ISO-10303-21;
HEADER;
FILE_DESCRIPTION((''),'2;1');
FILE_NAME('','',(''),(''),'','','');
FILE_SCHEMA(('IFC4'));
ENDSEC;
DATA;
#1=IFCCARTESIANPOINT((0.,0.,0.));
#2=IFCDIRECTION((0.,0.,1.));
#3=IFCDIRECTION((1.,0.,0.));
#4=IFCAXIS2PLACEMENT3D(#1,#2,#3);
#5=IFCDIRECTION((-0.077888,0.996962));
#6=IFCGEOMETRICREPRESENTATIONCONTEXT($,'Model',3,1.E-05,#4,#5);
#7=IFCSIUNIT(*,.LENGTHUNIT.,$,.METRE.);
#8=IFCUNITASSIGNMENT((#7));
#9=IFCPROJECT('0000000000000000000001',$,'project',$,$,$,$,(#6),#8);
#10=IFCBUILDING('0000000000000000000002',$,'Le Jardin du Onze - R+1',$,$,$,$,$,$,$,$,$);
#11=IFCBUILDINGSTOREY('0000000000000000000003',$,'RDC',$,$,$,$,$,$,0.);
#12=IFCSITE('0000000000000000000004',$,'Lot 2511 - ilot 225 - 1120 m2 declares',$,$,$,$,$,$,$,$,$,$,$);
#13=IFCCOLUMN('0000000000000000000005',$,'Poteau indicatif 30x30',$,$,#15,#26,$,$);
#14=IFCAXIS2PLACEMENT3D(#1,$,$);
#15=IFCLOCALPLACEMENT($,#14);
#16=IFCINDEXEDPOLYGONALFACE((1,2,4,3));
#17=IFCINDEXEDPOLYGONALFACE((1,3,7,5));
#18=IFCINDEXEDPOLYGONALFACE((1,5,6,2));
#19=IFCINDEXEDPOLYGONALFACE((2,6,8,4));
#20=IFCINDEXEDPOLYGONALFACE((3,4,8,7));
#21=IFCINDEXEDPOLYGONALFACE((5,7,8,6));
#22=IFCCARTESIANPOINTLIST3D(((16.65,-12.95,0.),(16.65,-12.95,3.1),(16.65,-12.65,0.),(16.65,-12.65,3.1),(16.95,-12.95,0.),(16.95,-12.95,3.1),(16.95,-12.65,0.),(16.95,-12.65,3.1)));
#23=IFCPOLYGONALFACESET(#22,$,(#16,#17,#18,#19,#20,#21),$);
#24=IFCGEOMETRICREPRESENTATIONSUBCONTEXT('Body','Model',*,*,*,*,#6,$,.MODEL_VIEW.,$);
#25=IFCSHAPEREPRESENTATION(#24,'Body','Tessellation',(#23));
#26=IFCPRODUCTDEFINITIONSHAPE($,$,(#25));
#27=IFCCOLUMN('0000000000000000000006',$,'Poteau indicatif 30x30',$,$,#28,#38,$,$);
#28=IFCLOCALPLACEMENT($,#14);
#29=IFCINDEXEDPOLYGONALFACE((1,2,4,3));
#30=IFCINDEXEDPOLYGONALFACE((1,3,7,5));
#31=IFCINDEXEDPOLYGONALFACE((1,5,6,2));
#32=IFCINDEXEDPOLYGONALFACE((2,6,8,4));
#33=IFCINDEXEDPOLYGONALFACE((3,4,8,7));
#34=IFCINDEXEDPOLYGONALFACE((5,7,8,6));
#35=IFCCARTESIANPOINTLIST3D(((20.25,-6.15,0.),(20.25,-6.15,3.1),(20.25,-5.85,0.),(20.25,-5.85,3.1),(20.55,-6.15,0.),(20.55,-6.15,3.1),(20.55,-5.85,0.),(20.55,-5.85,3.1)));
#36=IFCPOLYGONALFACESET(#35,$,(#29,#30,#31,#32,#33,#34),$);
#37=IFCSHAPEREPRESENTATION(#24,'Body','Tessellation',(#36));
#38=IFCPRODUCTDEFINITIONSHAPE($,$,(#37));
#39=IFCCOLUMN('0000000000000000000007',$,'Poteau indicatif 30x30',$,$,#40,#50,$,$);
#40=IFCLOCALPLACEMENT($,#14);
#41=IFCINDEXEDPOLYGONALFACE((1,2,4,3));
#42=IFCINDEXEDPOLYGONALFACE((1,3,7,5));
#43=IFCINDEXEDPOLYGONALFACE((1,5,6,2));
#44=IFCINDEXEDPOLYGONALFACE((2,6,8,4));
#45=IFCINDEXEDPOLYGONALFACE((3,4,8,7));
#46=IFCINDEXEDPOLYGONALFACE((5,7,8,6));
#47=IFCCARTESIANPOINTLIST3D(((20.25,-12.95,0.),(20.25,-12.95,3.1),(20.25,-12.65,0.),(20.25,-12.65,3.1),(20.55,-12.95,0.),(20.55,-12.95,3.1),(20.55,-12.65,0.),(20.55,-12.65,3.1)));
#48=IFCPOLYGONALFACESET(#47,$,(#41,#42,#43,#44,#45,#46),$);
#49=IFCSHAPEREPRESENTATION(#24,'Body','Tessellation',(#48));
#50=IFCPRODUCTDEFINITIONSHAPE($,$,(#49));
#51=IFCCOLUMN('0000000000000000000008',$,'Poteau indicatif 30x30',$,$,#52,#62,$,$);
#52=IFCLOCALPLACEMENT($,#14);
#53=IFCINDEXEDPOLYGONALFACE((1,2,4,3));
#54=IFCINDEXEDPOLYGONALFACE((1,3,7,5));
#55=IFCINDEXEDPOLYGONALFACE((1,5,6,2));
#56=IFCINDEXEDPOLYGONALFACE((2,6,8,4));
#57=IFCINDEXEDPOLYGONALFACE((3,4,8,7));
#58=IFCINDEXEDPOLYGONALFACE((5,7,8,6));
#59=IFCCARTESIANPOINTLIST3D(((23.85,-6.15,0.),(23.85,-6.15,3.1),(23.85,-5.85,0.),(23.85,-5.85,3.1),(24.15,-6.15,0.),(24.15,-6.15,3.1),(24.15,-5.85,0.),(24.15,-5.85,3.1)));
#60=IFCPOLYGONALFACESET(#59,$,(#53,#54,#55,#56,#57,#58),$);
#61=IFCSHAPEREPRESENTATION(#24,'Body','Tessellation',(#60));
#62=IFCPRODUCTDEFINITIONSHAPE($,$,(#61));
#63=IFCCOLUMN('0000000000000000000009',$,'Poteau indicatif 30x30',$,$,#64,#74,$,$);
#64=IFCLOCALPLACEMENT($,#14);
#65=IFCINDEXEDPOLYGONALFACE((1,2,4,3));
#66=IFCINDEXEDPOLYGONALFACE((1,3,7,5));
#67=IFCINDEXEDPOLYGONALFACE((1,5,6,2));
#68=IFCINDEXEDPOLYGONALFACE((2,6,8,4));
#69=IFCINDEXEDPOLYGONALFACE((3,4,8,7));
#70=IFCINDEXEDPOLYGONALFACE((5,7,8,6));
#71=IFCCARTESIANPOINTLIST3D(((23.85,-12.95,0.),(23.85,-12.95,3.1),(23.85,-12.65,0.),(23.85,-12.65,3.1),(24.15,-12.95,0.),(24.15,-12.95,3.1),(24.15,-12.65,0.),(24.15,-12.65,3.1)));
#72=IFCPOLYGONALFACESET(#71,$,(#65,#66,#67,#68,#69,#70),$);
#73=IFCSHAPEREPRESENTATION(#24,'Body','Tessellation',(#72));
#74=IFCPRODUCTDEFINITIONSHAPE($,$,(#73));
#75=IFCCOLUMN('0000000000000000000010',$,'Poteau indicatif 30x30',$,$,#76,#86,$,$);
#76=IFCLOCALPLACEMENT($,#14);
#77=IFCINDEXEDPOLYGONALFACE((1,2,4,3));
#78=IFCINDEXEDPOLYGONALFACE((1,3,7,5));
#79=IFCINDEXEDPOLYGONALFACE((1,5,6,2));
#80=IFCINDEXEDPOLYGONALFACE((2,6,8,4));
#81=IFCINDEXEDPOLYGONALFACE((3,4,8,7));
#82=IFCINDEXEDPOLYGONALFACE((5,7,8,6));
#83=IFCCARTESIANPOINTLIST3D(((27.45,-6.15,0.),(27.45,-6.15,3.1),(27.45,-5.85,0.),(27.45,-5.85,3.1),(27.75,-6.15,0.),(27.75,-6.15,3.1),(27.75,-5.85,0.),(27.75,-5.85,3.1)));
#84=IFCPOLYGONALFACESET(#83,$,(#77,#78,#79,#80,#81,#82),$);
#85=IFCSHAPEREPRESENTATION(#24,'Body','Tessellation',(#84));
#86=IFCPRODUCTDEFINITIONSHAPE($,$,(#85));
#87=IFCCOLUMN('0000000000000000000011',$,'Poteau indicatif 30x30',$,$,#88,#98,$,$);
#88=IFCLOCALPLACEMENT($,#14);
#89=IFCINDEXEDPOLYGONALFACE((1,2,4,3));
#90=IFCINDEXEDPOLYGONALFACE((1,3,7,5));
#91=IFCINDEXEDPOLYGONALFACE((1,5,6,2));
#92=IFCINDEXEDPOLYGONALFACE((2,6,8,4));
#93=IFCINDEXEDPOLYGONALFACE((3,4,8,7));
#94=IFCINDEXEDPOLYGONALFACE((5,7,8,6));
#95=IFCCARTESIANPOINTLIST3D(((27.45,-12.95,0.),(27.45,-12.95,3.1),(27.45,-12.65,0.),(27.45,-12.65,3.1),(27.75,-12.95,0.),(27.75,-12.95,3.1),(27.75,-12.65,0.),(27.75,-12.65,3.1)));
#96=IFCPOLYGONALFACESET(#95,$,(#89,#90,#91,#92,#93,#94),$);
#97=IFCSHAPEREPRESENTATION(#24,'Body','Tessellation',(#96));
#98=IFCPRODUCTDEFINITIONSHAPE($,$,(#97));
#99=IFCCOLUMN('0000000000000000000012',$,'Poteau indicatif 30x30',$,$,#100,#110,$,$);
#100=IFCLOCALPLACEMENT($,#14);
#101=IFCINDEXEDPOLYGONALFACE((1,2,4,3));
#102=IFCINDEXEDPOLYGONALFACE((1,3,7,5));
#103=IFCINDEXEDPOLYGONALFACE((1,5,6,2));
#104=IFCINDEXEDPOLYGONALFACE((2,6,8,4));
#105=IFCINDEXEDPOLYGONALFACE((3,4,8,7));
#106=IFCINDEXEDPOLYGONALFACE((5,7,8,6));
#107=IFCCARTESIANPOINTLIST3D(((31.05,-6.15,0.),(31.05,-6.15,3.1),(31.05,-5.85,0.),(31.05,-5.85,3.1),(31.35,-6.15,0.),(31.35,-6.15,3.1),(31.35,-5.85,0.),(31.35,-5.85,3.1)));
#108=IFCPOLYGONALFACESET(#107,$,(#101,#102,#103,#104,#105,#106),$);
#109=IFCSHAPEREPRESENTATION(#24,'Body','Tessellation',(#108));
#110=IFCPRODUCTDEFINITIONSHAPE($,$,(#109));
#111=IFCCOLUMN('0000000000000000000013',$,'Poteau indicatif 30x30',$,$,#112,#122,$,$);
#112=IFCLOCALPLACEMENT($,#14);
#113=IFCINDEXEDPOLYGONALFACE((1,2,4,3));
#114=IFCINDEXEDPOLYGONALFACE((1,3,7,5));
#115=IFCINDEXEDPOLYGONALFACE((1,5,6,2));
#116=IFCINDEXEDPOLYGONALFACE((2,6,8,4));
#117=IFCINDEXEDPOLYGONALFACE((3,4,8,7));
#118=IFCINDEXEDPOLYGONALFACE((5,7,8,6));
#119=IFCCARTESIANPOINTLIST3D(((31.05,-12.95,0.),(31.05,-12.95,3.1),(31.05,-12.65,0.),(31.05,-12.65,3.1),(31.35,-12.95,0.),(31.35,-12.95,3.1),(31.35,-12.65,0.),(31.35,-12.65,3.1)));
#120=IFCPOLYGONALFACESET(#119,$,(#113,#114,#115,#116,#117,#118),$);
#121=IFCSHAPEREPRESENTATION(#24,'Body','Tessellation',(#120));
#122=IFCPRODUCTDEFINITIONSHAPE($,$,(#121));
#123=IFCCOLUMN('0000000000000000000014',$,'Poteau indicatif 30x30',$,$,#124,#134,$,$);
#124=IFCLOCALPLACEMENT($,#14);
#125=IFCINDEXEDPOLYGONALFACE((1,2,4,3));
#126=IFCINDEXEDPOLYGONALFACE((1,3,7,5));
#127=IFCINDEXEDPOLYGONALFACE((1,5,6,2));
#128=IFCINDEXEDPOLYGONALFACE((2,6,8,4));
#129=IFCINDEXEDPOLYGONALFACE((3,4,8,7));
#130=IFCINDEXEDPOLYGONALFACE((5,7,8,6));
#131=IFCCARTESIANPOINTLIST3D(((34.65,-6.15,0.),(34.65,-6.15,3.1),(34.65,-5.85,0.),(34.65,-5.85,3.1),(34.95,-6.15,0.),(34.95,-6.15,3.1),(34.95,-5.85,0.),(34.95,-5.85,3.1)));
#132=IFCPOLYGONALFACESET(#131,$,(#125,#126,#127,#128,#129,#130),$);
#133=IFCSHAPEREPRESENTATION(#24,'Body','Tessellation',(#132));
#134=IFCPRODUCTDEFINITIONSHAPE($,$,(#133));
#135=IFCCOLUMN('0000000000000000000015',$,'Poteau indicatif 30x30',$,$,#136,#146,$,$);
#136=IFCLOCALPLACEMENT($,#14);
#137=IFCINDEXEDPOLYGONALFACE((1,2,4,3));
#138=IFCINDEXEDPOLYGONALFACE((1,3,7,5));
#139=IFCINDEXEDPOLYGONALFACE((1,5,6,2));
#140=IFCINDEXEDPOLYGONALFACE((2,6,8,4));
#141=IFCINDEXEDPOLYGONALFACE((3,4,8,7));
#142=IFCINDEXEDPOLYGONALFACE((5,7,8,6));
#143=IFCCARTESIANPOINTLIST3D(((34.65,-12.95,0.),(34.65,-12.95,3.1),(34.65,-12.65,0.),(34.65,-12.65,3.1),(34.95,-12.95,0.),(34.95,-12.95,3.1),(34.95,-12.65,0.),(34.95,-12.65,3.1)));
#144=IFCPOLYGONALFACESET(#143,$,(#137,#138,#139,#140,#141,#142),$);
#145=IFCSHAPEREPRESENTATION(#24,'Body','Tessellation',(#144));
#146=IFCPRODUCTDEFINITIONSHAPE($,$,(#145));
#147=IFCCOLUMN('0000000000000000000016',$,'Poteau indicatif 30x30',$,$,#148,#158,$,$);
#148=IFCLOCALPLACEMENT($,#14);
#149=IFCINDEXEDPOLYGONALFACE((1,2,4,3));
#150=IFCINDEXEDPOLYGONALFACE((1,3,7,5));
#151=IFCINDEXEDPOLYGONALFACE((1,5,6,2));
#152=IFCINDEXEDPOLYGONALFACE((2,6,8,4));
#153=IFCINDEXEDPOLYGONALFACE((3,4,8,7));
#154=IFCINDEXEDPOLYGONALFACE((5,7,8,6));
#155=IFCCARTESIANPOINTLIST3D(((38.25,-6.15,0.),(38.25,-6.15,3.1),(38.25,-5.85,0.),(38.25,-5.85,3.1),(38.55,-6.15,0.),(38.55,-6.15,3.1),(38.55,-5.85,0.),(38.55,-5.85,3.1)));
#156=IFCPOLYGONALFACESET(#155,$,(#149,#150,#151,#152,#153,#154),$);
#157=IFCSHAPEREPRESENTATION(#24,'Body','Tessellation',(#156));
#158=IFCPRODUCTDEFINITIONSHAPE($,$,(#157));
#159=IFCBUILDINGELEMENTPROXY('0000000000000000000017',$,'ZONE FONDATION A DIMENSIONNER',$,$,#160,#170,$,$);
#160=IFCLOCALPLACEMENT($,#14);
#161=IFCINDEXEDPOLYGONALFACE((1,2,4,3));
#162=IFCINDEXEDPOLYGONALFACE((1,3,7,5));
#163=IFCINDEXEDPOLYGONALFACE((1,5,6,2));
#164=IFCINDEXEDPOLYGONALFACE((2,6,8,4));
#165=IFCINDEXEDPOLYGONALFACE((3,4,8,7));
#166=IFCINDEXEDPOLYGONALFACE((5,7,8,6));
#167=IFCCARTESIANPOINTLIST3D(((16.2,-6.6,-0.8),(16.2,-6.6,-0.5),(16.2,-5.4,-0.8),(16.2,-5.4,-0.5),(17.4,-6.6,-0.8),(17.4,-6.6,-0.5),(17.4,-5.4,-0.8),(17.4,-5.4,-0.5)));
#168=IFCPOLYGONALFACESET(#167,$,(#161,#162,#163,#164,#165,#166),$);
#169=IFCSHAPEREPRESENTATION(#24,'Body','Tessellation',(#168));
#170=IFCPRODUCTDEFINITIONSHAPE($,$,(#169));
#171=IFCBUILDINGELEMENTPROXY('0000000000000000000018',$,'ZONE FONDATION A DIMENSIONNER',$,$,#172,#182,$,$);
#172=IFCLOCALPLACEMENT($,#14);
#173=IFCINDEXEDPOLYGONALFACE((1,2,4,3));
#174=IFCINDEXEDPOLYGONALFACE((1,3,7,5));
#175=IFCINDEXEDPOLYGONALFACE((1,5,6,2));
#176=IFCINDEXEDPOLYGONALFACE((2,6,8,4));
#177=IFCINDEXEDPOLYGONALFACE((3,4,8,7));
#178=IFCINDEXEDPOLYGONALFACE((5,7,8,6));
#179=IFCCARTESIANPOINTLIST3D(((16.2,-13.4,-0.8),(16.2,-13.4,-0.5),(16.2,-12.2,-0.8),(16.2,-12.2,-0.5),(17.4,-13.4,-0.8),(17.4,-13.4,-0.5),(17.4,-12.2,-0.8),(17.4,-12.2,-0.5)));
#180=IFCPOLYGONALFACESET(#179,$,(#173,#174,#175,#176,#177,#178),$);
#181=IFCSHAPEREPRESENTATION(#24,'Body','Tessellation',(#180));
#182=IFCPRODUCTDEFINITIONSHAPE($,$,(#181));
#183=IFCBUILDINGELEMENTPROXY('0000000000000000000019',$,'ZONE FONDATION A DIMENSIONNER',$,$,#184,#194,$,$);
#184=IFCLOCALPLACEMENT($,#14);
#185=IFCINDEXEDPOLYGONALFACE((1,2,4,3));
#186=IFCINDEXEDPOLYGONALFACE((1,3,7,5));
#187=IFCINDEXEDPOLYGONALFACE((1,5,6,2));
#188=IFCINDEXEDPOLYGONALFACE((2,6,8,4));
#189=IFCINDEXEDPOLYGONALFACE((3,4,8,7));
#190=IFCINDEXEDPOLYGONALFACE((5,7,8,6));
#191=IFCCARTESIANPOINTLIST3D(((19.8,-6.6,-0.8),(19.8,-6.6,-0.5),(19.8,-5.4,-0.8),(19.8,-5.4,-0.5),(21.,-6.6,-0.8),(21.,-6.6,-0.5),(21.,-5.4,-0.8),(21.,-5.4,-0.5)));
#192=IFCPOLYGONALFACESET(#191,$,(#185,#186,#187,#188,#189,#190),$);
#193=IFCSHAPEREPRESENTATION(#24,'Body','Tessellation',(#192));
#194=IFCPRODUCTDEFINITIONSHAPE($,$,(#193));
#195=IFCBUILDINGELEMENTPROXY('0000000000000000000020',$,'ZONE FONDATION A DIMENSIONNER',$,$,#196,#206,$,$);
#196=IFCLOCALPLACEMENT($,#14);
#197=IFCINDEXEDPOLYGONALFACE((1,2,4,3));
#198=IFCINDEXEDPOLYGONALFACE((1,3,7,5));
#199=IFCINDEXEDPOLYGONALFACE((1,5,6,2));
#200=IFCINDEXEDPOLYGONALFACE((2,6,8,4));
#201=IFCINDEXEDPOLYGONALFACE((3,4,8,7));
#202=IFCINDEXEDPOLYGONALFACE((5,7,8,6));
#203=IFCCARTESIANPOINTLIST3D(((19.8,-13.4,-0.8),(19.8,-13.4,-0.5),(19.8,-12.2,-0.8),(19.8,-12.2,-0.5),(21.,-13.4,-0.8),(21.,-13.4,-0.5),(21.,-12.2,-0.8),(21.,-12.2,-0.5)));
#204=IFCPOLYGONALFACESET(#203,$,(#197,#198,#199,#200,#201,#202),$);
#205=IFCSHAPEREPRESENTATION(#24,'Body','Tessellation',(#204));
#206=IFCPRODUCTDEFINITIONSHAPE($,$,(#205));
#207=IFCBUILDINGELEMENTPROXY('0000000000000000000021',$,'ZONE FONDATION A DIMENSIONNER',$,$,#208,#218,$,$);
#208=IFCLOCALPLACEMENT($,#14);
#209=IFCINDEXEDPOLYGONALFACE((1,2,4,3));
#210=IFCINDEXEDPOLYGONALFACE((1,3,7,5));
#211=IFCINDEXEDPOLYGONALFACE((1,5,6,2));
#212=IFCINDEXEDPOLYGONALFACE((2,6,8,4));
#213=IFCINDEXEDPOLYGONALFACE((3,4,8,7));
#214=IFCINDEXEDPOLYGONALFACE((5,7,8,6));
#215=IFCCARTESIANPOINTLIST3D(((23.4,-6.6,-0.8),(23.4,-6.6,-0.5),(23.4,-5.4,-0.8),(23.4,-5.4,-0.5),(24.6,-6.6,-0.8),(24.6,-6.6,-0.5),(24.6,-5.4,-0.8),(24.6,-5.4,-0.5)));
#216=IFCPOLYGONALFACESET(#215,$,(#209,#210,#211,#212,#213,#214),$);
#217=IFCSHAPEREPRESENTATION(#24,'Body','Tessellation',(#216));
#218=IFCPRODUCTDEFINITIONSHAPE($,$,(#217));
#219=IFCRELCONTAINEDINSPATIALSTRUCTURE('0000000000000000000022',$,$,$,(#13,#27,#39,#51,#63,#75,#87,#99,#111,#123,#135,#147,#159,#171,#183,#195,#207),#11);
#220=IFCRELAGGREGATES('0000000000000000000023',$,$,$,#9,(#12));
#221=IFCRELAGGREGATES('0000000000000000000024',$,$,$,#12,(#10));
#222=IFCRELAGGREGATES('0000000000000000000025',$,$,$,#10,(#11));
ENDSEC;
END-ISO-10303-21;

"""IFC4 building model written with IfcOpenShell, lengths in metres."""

from ifc_helpers import new_model, si_unit, direction, frame, origin, origin_with_axes, place, context, subcontext, project, spatial, polyline, outline, extrude, element, save


model = new_model("IFC4")

# Units and contexts
model_context = context("Model", 3, precision=1e-05, world=origin_with_axes(), true_north=direction((-0.077888, 0.996962)))
body_context = subcontext(model_context, "Body", "Model", "MODEL_VIEW")
ifc_project = project(units=[si_unit("LENGTHUNIT", "METRE")], contexts=[model_context])

# Site, building, storey
site = spatial("IfcSite", under=ifc_project, Name="Lot 2511 - ilot 225 - 1120 m2 declares")
building = spatial("IfcBuilding", under=site, Name="Le Jardin du Onze - R+1")
storey = spatial("IfcBuildingStorey", under=building, Name="RDC", Elevation=0.0)

# Columns
column_1_placement = place(None, origin_with_axes())
element("IfcColumn", 1, at=column_1_placement, inside=storey, Name="Poteau indicatif 30x30", context=body_context, shape_type="SweptSolid", body=[
    extrude(outline(polyline([(16.95, -12.95), (16.95, -12.65), (16.65, -12.65), (16.65, -12.95), (16.95, -12.95)])), origin(), (0.0, 0.0, 1.0), 3.1),
])
column_2_placement = place(None, origin_with_axes())
element("IfcColumn", 2, at=column_2_placement, inside=storey, Name="Poteau indicatif 30x30", context=body_context, shape_type="SweptSolid", body=[
    extrude(outline(polyline([(20.55, -6.15), (20.55, -5.85), (20.25, -5.85), (20.25, -6.15), (20.55, -6.15)])), origin(), (0.0, 0.0, 1.0), 3.1),
])
column_3_placement = place(None, origin_with_axes())
element("IfcColumn", 3, at=column_3_placement, inside=storey, Name="Poteau indicatif 30x30", context=body_context, shape_type="SweptSolid", body=[
    extrude(outline(polyline([(20.55, -12.95), (20.55, -12.65), (20.25, -12.65), (20.25, -12.95), (20.55, -12.95)])), origin(), (0.0, 0.0, 1.0), 3.1),
])
column_4_placement = place(None, origin_with_axes())
element("IfcColumn", 4, at=column_4_placement, inside=storey, Name="Poteau indicatif 30x30", context=body_context, shape_type="SweptSolid", body=[
    extrude(outline(polyline([(24.15, -6.15), (24.15, -5.85), (23.85, -5.85), (23.85, -6.15), (24.15, -6.15)])), origin(), (0.0, 0.0, 1.0), 3.1),
])
column_5_placement = place(None, origin_with_axes())
element("IfcColumn", 5, at=column_5_placement, inside=storey, Name="Poteau indicatif 30x30", context=body_context, shape_type="SweptSolid", body=[
    extrude(outline(polyline([(24.15, -12.95), (24.15, -12.65), (23.85, -12.65), (23.85, -12.95), (24.15, -12.95)])), origin(), (0.0, 0.0, 1.0), 3.1),
])
column_6_placement = place(None, origin_with_axes())
element("IfcColumn", 6, at=column_6_placement, inside=storey, Name="Poteau indicatif 30x30", context=body_context, shape_type="SweptSolid", body=[
    extrude(outline(polyline([(27.75, -6.15), (27.75, -5.85), (27.45, -5.85), (27.45, -6.15), (27.75, -6.15)])), origin(), (0.0, 0.0, 1.0), 3.1),
])
column_7_placement = place(None, origin_with_axes())
element("IfcColumn", 7, at=column_7_placement, inside=storey, Name="Poteau indicatif 30x30", context=body_context, shape_type="SweptSolid", body=[
    extrude(outline(polyline([(27.75, -12.95), (27.75, -12.65), (27.45, -12.65), (27.45, -12.95), (27.75, -12.95)])), origin(), (0.0, 0.0, 1.0), 3.1),
])
column_8_placement = place(None, origin_with_axes())
element("IfcColumn", 8, at=column_8_placement, inside=storey, Name="Poteau indicatif 30x30", context=body_context, shape_type="SweptSolid", body=[
    extrude(outline(polyline([(31.35, -6.15), (31.35, -5.85), (31.05, -5.85), (31.05, -6.15), (31.35, -6.15)])), origin(), (0.0, 0.0, 1.0), 3.1),
])
column_9_placement = place(None, origin_with_axes())
element("IfcColumn", 9, at=column_9_placement, inside=storey, Name="Poteau indicatif 30x30", context=body_context, shape_type="SweptSolid", body=[
    extrude(outline(polyline([(31.35, -12.95), (31.35, -12.65), (31.05, -12.65), (31.05, -12.95), (31.35, -12.95)])), origin(), (0.0, 0.0, 1.0), 3.1),
])
column_10_placement = place(None, origin_with_axes())
element("IfcColumn", 10, at=column_10_placement, inside=storey, Name="Poteau indicatif 30x30", context=body_context, shape_type="SweptSolid", body=[
    extrude(outline(polyline([(34.95, -6.15), (34.95, -5.85), (34.65, -5.85), (34.65, -6.15), (34.95, -6.15)])), origin(), (0.0, 0.0, 1.0), 3.1),
])
column_11_placement = place(None, origin_with_axes())
element("IfcColumn", 11, at=column_11_placement, inside=storey, Name="Poteau indicatif 30x30", context=body_context, shape_type="SweptSolid", body=[
    extrude(outline(polyline([(34.95, -12.95), (34.95, -12.65), (34.65, -12.65), (34.65, -12.95), (34.95, -12.95)])), origin(), (0.0, 0.0, 1.0), 3.1),
])
column_12_placement = place(None, origin_with_axes())
element("IfcColumn", 12, at=column_12_placement, inside=storey, Name="Poteau indicatif 30x30", context=body_context, shape_type="SweptSolid", body=[
    extrude(outline(polyline([(38.55, -6.15), (38.55, -5.85), (38.25, -5.85), (38.25, -6.15), (38.55, -6.15)])), origin(), (0.0, 0.0, 1.0), 3.1),
])

# Building element proxies
proxy_1_placement = place(None, origin_with_axes())
element("IfcBuildingElementProxy", 13, at=proxy_1_placement, inside=storey, Name="ZONE FONDATION A DIMENSIONNER", context=body_context, shape_type="SweptSolid", body=[
    extrude(outline(polyline([(17.4, -6.6), (17.4, -5.4), (16.2, -5.4), (16.2, -6.6), (17.4, -6.6)])), frame((0.0, 0.0, -0.8)), (0.0, 0.0, 1.0), 0.3),
])
proxy_2_placement = place(None, origin_with_axes())
element("IfcBuildingElementProxy", 14, at=proxy_2_placement, inside=storey, Name="ZONE FONDATION A DIMENSIONNER", context=body_context, shape_type="SweptSolid", body=[
    extrude(outline(polyline([(17.4, -13.4), (17.4, -12.2), (16.2, -12.2), (16.2, -13.4), (17.4, -13.4)])), frame((0.0, 0.0, -0.8)), (0.0, 0.0, 1.0), 0.3),
])
proxy_3_placement = place(None, origin_with_axes())
element("IfcBuildingElementProxy", 15, at=proxy_3_placement, inside=storey, Name="ZONE FONDATION A DIMENSIONNER", context=body_context, shape_type="SweptSolid", body=[
    extrude(outline(polyline([(21.0, -6.6), (21.0, -5.4), (19.8, -5.4), (19.8, -6.6), (21.0, -6.6)])), frame((0.0, 0.0, -0.8)), (0.0, 0.0, 1.0), 0.3),
])
proxy_4_placement = place(None, origin_with_axes())
element("IfcBuildingElementProxy", 16, at=proxy_4_placement, inside=storey, Name="ZONE FONDATION A DIMENSIONNER", context=body_context, shape_type="SweptSolid", body=[
    extrude(outline(polyline([(21.0, -13.4), (21.0, -12.2), (19.8, -12.2), (19.8, -13.4), (21.0, -13.4)])), frame((0.0, 0.0, -0.8)), (0.0, 0.0, 1.0), 0.3),
])
proxy_5_placement = place(None, origin_with_axes())
element("IfcBuildingElementProxy", 17, at=proxy_5_placement, inside=storey, Name="ZONE FONDATION A DIMENSIONNER", context=body_context, shape_type="SweptSolid", body=[
    extrude(outline(polyline([(24.6, -6.6), (24.6, -5.4), (23.4, -5.4), (23.4, -6.6), (24.6, -6.6)])), frame((0.0, 0.0, -0.8)), (0.0, 0.0, 1.0), 0.3),
])

save(model, "model.ifc")
